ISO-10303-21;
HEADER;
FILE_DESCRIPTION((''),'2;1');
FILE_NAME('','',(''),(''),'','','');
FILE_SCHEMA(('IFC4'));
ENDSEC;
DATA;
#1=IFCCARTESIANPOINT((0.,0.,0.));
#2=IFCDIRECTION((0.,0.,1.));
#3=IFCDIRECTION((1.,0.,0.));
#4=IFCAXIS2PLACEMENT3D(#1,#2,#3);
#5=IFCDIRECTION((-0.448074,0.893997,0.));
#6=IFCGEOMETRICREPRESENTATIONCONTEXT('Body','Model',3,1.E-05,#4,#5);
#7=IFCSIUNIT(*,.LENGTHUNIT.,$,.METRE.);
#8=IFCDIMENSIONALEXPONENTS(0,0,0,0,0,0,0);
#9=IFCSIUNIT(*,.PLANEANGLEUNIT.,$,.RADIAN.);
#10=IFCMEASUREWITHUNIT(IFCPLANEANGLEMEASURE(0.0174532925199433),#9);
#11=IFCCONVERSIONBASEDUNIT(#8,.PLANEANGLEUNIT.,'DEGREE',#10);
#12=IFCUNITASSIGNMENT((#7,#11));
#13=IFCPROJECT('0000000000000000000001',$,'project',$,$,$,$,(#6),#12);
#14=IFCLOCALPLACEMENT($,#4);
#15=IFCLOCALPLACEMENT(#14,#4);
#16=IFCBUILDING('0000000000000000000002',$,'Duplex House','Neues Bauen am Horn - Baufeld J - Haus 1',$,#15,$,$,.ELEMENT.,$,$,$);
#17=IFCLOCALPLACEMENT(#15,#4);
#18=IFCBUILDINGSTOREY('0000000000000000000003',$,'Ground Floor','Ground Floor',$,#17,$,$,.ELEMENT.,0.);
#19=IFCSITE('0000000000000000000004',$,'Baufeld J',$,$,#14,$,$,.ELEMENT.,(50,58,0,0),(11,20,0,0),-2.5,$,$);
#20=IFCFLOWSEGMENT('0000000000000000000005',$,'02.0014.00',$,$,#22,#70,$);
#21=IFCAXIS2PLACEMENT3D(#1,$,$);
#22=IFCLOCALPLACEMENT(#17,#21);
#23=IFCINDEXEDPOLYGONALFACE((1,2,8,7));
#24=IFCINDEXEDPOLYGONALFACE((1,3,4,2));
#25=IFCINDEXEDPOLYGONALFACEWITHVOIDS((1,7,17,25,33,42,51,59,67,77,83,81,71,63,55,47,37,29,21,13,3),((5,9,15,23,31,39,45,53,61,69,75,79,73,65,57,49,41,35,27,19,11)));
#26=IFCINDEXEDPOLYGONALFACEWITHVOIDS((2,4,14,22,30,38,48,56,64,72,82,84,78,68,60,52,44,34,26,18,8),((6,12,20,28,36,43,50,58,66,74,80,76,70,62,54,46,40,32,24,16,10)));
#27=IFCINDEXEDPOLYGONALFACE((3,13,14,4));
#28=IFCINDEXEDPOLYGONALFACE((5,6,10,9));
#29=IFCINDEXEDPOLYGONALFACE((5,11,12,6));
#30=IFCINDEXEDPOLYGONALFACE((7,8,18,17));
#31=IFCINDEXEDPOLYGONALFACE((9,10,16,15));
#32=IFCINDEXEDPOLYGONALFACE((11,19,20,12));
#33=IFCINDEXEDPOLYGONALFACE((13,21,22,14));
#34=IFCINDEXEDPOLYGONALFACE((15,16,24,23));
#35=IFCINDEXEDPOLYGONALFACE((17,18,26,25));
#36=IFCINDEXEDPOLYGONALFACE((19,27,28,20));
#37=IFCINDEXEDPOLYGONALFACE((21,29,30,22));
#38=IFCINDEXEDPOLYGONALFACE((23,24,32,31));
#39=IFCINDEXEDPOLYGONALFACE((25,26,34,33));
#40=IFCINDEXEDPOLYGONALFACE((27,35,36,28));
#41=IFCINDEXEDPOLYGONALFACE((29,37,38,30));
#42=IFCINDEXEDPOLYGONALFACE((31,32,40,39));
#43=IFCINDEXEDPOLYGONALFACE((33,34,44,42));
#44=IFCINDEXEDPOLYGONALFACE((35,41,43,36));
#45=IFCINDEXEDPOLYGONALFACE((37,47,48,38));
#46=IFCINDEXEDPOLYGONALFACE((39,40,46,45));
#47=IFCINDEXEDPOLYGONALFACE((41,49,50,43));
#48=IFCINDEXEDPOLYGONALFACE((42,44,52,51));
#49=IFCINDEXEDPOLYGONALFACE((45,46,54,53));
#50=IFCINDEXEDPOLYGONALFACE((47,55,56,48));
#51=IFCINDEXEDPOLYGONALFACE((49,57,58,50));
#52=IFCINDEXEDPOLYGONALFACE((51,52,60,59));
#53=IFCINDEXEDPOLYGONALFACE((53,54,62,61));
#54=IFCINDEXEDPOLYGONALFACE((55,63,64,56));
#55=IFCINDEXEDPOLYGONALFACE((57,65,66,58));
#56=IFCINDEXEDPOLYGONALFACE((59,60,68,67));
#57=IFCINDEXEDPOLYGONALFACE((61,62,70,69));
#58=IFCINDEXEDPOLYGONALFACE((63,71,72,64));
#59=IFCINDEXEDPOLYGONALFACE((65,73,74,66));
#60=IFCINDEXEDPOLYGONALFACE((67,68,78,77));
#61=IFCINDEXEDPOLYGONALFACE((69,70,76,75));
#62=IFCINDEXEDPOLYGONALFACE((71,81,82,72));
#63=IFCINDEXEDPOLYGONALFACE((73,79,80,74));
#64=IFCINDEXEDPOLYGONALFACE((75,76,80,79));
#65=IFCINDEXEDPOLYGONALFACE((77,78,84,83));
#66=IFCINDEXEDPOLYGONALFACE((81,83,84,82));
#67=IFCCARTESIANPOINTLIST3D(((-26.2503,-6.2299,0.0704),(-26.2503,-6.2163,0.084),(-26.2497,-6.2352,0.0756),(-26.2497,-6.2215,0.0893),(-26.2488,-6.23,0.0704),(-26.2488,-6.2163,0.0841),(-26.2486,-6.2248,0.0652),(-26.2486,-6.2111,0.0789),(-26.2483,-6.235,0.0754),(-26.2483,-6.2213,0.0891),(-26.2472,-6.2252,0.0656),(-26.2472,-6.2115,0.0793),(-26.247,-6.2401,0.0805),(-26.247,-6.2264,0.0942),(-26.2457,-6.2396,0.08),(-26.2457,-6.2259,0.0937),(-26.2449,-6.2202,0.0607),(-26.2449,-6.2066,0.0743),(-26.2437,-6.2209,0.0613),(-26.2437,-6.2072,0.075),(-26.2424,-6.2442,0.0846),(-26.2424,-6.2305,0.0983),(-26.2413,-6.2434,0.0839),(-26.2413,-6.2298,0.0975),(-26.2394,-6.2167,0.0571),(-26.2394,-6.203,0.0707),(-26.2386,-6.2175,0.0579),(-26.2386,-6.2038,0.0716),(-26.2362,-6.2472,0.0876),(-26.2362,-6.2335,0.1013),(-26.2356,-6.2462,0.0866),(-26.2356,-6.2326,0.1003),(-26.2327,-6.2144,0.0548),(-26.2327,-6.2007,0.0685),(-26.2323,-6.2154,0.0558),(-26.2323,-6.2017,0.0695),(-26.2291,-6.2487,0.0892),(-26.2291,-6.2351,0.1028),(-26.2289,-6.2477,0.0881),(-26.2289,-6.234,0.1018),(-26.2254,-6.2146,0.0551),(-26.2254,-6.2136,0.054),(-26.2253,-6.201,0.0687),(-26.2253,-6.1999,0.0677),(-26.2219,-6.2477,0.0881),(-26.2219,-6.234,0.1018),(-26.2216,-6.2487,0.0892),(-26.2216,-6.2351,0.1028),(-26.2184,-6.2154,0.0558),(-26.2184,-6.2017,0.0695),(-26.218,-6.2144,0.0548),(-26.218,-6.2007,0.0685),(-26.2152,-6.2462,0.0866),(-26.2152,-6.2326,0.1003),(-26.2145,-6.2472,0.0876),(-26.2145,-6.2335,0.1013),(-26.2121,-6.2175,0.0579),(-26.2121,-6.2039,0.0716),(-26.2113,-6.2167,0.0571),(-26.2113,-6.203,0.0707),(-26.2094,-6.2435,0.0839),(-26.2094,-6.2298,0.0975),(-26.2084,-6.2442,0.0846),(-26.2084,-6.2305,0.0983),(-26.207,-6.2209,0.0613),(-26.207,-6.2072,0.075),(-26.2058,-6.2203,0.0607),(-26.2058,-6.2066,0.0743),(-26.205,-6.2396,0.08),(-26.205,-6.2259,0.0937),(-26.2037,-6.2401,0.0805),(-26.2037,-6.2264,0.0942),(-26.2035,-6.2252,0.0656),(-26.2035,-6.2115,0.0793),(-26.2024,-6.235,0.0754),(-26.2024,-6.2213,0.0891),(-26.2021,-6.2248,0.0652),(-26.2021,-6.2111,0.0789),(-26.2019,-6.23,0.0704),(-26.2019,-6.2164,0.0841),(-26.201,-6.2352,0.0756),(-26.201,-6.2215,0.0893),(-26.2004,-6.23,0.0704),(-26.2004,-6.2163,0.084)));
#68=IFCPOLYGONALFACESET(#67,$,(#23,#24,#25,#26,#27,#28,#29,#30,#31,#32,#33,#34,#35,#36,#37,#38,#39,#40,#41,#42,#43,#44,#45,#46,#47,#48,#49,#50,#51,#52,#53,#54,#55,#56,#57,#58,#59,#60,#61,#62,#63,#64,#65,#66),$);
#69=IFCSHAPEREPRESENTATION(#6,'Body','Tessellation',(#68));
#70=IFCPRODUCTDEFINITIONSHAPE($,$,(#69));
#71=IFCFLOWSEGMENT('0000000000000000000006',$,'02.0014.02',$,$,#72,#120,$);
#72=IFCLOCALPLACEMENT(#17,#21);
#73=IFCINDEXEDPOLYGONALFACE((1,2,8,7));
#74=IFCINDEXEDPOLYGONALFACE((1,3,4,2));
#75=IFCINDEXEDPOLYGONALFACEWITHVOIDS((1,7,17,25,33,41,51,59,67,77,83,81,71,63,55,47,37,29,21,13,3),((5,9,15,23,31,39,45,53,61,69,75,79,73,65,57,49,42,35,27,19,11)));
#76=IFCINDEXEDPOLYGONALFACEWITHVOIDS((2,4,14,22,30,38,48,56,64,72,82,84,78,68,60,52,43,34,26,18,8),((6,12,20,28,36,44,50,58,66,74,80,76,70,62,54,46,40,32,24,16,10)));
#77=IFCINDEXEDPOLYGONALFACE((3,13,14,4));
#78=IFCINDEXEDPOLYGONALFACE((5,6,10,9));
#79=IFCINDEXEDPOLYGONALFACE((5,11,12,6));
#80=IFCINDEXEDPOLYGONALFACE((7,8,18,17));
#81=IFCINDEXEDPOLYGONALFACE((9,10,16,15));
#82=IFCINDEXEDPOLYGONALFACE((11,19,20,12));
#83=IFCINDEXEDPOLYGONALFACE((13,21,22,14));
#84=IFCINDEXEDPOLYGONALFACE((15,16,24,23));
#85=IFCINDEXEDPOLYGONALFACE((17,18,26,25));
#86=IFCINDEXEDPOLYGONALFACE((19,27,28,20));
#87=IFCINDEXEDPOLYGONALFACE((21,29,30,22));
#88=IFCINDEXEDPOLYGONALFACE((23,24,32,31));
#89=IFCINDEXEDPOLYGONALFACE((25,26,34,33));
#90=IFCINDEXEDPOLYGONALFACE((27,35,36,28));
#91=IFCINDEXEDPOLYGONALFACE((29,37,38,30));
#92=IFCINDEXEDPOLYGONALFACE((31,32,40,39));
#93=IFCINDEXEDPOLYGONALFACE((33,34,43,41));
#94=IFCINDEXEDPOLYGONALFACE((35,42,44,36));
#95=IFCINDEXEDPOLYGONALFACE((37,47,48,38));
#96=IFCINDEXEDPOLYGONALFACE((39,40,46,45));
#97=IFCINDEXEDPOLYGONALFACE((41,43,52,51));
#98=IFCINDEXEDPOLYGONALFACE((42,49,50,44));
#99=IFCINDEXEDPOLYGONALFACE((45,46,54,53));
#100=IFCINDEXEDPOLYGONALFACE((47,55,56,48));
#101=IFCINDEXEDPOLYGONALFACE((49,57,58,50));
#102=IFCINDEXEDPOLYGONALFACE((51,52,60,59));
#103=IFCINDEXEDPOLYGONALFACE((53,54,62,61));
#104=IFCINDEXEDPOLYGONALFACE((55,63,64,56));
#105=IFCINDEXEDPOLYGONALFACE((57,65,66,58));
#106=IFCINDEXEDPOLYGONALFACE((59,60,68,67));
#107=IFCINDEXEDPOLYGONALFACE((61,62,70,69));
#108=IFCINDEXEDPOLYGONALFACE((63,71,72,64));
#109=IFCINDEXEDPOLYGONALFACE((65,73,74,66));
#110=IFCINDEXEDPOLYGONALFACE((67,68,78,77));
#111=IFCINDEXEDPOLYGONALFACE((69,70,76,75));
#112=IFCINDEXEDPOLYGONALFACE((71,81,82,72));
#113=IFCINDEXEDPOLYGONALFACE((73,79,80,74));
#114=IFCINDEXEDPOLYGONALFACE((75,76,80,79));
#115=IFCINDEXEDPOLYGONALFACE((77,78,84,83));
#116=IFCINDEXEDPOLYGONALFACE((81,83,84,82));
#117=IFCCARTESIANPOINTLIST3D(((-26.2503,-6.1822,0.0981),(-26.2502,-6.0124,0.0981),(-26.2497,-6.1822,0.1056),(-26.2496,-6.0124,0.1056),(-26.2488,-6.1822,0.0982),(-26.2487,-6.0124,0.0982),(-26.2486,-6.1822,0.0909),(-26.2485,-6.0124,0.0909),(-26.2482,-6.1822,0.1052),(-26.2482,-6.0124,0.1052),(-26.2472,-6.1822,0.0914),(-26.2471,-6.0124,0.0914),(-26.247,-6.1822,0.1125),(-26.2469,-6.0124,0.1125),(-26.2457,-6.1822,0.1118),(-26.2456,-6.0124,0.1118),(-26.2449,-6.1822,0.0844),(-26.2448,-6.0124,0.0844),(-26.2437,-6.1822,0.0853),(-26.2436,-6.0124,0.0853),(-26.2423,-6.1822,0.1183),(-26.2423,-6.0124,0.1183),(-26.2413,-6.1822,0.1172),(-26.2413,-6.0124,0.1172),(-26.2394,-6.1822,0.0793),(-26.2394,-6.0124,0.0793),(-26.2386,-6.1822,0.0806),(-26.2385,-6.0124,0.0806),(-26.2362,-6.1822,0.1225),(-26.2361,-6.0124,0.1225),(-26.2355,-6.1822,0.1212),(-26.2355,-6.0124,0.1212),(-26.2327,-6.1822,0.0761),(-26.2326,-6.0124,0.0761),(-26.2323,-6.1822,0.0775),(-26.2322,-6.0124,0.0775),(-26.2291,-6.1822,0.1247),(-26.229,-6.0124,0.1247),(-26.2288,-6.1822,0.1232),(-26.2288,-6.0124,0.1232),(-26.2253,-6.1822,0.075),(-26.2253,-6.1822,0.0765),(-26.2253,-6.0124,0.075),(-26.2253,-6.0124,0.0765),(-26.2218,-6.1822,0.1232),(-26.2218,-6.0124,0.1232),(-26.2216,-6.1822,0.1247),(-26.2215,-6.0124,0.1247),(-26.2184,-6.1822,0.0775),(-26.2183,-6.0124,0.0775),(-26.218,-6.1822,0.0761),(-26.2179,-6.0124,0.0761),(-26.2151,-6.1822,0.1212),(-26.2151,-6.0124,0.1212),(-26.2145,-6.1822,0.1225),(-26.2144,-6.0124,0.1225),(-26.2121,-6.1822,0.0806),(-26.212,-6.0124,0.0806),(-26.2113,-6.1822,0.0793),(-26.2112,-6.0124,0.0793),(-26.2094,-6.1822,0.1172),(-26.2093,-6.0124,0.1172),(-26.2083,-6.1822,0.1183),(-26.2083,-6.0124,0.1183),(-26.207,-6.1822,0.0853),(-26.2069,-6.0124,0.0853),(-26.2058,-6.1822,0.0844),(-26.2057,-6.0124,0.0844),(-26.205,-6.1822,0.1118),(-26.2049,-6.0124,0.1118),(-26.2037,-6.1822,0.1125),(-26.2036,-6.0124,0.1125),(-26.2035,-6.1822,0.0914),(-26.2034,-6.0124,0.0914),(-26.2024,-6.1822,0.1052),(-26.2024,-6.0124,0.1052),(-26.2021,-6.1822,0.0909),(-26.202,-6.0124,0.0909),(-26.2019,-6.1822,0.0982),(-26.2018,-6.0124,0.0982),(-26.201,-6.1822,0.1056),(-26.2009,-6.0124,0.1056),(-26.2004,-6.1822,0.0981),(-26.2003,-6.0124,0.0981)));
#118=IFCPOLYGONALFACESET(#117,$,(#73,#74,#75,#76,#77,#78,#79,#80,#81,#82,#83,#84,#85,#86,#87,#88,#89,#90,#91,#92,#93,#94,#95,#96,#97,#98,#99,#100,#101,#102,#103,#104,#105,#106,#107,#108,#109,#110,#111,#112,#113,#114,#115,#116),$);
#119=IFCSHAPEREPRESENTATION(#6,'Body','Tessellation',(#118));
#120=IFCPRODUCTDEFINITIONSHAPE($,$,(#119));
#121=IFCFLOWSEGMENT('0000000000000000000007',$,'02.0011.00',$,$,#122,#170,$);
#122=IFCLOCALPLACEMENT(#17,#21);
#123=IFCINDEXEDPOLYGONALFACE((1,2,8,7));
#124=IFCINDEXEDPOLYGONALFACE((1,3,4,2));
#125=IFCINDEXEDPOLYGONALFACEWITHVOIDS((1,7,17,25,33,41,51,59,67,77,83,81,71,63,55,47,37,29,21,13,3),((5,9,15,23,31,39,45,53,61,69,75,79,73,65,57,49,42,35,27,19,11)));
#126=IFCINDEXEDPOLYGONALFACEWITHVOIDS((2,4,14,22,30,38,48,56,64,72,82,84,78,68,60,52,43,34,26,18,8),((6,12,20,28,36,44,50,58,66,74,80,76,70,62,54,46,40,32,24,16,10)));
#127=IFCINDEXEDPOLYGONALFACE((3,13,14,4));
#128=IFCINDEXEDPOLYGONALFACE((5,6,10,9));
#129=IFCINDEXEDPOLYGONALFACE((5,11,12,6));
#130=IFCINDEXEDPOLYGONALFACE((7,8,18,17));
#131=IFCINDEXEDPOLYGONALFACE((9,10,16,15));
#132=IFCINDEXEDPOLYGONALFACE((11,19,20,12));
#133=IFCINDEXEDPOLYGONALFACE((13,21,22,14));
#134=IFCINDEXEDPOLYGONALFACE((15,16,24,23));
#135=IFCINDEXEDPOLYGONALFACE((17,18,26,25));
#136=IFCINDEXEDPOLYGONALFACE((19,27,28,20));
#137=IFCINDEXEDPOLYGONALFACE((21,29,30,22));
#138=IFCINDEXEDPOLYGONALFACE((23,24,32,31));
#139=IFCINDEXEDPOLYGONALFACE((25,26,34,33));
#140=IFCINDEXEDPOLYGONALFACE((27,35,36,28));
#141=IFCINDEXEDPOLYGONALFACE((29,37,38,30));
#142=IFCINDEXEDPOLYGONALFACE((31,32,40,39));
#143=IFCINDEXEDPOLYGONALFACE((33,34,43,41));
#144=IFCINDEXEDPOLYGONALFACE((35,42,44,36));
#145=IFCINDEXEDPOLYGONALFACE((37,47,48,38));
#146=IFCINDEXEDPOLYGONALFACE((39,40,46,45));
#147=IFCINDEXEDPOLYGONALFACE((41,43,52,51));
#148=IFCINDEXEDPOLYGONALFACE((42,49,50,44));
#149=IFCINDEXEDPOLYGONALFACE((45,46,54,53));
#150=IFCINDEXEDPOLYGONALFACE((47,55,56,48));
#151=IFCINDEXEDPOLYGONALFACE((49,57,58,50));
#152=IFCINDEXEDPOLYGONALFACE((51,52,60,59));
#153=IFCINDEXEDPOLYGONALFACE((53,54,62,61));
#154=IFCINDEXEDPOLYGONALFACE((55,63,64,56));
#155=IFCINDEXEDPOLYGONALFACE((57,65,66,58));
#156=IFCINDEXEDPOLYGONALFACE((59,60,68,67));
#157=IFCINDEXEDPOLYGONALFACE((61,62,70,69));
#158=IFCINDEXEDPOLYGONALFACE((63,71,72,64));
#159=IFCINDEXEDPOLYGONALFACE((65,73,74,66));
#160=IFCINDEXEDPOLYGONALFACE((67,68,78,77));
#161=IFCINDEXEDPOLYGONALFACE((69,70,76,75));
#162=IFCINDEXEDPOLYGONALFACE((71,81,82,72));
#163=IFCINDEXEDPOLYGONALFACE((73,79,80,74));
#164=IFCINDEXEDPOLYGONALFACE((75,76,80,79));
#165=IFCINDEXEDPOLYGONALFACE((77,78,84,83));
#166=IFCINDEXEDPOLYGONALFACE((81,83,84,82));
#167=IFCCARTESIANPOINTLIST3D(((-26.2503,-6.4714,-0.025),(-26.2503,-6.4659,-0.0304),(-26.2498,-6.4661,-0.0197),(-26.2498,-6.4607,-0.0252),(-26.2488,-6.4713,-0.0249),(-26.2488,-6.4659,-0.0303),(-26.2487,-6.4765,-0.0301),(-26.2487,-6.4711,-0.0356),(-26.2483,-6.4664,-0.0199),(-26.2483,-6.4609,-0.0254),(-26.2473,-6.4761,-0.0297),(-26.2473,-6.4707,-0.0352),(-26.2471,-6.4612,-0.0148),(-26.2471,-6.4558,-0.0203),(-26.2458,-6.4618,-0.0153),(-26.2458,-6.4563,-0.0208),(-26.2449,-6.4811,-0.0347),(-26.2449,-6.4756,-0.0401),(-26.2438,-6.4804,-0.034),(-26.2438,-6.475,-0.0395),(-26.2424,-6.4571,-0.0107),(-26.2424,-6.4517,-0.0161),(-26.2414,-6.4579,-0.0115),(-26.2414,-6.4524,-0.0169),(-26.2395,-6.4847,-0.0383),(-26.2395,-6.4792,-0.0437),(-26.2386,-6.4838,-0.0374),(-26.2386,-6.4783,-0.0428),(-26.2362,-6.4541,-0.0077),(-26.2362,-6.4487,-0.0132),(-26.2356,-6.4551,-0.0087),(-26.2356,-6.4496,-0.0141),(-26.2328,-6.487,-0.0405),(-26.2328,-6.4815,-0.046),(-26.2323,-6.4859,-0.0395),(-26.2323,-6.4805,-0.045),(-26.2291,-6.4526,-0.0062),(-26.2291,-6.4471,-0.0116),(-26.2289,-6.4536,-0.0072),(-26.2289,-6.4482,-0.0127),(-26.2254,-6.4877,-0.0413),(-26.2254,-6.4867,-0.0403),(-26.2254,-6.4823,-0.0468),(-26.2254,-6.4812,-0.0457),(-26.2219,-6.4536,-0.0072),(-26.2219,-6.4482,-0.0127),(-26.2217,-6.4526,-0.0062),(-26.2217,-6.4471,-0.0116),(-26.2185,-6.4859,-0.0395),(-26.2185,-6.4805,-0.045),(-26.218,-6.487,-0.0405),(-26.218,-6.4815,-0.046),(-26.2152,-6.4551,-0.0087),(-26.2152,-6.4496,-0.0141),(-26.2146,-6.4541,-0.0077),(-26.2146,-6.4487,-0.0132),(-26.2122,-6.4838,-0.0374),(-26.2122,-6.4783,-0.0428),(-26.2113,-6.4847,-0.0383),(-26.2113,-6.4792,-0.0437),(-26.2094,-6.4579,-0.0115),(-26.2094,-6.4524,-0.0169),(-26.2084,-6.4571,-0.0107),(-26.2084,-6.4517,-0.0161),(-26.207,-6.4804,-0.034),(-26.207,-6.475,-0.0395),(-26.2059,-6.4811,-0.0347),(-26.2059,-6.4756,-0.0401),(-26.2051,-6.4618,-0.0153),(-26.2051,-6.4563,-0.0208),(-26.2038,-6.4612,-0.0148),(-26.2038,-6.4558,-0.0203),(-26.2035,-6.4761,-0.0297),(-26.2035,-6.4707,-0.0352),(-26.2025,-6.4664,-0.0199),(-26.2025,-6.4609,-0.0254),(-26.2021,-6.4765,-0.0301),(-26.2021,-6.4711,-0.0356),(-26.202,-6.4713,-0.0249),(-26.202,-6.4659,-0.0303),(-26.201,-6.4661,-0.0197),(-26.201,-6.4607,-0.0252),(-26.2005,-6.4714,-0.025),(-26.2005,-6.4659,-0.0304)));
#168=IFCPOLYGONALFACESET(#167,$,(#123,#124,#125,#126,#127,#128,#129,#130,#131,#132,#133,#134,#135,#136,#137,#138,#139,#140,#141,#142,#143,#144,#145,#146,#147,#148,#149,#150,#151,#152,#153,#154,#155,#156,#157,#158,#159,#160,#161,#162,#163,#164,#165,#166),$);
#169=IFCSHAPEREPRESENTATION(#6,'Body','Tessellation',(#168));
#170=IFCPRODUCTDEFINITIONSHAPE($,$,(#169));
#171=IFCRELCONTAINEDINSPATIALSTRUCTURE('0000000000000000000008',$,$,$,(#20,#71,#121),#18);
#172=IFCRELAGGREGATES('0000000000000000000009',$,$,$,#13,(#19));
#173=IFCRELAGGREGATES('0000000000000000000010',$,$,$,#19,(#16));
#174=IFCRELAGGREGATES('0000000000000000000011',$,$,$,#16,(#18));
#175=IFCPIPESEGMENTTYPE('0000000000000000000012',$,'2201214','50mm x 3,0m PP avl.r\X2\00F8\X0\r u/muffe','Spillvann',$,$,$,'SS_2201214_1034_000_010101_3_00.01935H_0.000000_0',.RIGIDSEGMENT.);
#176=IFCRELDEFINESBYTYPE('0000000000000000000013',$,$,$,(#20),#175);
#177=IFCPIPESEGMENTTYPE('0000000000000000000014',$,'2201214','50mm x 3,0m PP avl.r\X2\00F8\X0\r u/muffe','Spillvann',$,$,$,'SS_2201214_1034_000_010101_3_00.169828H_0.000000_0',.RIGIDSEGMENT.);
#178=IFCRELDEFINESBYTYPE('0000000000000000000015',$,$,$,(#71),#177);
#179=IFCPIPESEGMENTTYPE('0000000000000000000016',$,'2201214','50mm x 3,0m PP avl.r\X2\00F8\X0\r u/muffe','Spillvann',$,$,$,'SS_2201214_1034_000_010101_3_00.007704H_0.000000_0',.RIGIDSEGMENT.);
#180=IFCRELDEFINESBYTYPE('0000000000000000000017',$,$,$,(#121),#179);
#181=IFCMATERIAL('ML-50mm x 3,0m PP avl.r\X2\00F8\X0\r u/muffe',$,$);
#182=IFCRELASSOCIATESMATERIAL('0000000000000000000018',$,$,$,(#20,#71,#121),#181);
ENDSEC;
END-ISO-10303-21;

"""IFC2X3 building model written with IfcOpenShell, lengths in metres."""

from ifc_helpers import new_model, entity, si_unit, converted_unit, direction, frame, origin_with_axes, origin_2d_with_axis, place, context, project, spatial, hollow_circle, extrude, material, type_object, element, save


model = new_model("IFC2X3")

# Units and contexts
model_context = context("Model", 3, precision=1e-05, world=origin_with_axes(), true_north=direction((-0.448074, 0.893997, 0.0)), identifier="Body")
ifc_project = project(units=[si_unit("LENGTHUNIT", "METRE"), converted_unit("PLANEANGLEUNIT", "DEGREE", entity("IfcPlaneAngleMeasure", 0.0174532925199433), si_unit("PLANEANGLEUNIT", "RADIAN"), dimensions=[0, 0, 0, 0, 0, 0, 0])], contexts=[model_context])

# Site, building, storey
site_placement = place(None, origin_with_axes())
site = spatial("IfcSite", under=ifc_project, at=site_placement, Name="Baufeld J", CompositionType="ELEMENT", RefLatitude=(50, 58, 0, 0), RefLongitude=(11, 20, 0, 0), RefElevation=-2.5)
building_placement = place(site_placement, origin_with_axes())
building = spatial("IfcBuilding", under=site, at=building_placement, Name="Duplex House", Description="Neues Bauen am Horn - Baufeld J - Haus 1", CompositionType="ELEMENT")
storey_placement = place(building_placement, origin_with_axes())
storey = spatial("IfcBuildingStorey", under=building, at=storey_placement, Name="Ground Floor", Description="Ground Floor", CompositionType="ELEMENT", Elevation=0.0)

# Flow segments
ifc_material_1 = material(Name="ML-50mm x 3,0m PP avl.rør u/muffe")
pipe_segment_type_1 = type_object("IfcPipeSegmentType", Name="2201214", Description="50mm x 3,0m PP avl.rør u/muffe", ApplicableOccurrence="Spillvann", ElementType="SS_2201214_1034_000_010101_3_00.01935H_0.000000_0", PredefinedType="RIGIDSEGMENT")
flow_segment_1_placement = place(storey_placement, frame((-26.2254, -6.2313, 0.0717), z_axis=(-0.000275, -0.707107, 0.707107), x_axis=(0.000275, 0.707107, 0.707107)))
element("IfcFlowSegment", 1, at=flow_segment_1_placement, inside=storey, type_object=pipe_segment_type_1, material=ifc_material_1, Name="02.0014.00", context=model_context, shape_type="SweptSolid", body=[
    extrude(hollow_circle(Radius=0.025, WallThickness=0.0015, at=origin_2d_with_axis()), frame((0.0, 0.0, 0.0), z_axis=(1.0, 0.0, 0.0), x_axis=(0.0, 0.0, -1.0)), (0.0, 0.0, 1.0), 0.0194),
])
pipe_segment_type_2 = type_object("IfcPipeSegmentType", Name="2201214", Description="50mm x 3,0m PP avl.rør u/muffe", ApplicableOccurrence="Spillvann", ElementType="SS_2201214_1034_000_010101_3_00.169828H_0.000000_0", PredefinedType="RIGIDSEGMENT")
flow_segment_2_placement = place(storey_placement, frame((-26.2253, -6.1822, 0.1), z_axis=(0.0, 0.0, 1.0), x_axis=(0.000389, 1.0, 0.0)))
element("IfcFlowSegment", 2, at=flow_segment_2_placement, inside=storey, type_object=pipe_segment_type_2, material=ifc_material_1, Name="02.0014.02", context=model_context, shape_type="SweptSolid", body=[
    extrude(hollow_circle(Radius=0.025, WallThickness=0.0015, at=origin_2d_with_axis()), frame((0.0, 0.0, 0.0), z_axis=(1.0, 0.0, 0.0), x_axis=(0.0, 0.0, -1.0)), (0.0, 0.0, 1.0), 0.1698),
])
pipe_segment_type_3 = type_object("IfcPipeSegmentType", Name="2201214", Description="50mm x 3,0m PP avl.rør u/muffe", ApplicableOccurrence="Spillvann", ElementType="SS_2201214_1034_000_010101_3_00.007704H_0.000000_0", PredefinedType="RIGIDSEGMENT")
flow_segment_3_placement = place(storey_placement, frame((-26.2254, -6.4646, -0.0291), z_axis=(0.0, 0.707107, 0.707107), x_axis=(0.0, -0.707107, 0.707107)))
element("IfcFlowSegment", 3, at=flow_segment_3_placement, inside=storey, type_object=pipe_segment_type_3, material=ifc_material_1, Name="02.0011.00", context=model_context, shape_type="SweptSolid", body=[
    extrude(hollow_circle(Radius=0.025, WallThickness=0.0015, at=origin_2d_with_axis()), frame((0.0, 0.0, 0.0), z_axis=(1.0, 0.0, 0.0), x_axis=(0.0, 0.0, -1.0)), (0.0, 0.0, 1.0), 0.0077),
])

save(model, "model.ifc")
